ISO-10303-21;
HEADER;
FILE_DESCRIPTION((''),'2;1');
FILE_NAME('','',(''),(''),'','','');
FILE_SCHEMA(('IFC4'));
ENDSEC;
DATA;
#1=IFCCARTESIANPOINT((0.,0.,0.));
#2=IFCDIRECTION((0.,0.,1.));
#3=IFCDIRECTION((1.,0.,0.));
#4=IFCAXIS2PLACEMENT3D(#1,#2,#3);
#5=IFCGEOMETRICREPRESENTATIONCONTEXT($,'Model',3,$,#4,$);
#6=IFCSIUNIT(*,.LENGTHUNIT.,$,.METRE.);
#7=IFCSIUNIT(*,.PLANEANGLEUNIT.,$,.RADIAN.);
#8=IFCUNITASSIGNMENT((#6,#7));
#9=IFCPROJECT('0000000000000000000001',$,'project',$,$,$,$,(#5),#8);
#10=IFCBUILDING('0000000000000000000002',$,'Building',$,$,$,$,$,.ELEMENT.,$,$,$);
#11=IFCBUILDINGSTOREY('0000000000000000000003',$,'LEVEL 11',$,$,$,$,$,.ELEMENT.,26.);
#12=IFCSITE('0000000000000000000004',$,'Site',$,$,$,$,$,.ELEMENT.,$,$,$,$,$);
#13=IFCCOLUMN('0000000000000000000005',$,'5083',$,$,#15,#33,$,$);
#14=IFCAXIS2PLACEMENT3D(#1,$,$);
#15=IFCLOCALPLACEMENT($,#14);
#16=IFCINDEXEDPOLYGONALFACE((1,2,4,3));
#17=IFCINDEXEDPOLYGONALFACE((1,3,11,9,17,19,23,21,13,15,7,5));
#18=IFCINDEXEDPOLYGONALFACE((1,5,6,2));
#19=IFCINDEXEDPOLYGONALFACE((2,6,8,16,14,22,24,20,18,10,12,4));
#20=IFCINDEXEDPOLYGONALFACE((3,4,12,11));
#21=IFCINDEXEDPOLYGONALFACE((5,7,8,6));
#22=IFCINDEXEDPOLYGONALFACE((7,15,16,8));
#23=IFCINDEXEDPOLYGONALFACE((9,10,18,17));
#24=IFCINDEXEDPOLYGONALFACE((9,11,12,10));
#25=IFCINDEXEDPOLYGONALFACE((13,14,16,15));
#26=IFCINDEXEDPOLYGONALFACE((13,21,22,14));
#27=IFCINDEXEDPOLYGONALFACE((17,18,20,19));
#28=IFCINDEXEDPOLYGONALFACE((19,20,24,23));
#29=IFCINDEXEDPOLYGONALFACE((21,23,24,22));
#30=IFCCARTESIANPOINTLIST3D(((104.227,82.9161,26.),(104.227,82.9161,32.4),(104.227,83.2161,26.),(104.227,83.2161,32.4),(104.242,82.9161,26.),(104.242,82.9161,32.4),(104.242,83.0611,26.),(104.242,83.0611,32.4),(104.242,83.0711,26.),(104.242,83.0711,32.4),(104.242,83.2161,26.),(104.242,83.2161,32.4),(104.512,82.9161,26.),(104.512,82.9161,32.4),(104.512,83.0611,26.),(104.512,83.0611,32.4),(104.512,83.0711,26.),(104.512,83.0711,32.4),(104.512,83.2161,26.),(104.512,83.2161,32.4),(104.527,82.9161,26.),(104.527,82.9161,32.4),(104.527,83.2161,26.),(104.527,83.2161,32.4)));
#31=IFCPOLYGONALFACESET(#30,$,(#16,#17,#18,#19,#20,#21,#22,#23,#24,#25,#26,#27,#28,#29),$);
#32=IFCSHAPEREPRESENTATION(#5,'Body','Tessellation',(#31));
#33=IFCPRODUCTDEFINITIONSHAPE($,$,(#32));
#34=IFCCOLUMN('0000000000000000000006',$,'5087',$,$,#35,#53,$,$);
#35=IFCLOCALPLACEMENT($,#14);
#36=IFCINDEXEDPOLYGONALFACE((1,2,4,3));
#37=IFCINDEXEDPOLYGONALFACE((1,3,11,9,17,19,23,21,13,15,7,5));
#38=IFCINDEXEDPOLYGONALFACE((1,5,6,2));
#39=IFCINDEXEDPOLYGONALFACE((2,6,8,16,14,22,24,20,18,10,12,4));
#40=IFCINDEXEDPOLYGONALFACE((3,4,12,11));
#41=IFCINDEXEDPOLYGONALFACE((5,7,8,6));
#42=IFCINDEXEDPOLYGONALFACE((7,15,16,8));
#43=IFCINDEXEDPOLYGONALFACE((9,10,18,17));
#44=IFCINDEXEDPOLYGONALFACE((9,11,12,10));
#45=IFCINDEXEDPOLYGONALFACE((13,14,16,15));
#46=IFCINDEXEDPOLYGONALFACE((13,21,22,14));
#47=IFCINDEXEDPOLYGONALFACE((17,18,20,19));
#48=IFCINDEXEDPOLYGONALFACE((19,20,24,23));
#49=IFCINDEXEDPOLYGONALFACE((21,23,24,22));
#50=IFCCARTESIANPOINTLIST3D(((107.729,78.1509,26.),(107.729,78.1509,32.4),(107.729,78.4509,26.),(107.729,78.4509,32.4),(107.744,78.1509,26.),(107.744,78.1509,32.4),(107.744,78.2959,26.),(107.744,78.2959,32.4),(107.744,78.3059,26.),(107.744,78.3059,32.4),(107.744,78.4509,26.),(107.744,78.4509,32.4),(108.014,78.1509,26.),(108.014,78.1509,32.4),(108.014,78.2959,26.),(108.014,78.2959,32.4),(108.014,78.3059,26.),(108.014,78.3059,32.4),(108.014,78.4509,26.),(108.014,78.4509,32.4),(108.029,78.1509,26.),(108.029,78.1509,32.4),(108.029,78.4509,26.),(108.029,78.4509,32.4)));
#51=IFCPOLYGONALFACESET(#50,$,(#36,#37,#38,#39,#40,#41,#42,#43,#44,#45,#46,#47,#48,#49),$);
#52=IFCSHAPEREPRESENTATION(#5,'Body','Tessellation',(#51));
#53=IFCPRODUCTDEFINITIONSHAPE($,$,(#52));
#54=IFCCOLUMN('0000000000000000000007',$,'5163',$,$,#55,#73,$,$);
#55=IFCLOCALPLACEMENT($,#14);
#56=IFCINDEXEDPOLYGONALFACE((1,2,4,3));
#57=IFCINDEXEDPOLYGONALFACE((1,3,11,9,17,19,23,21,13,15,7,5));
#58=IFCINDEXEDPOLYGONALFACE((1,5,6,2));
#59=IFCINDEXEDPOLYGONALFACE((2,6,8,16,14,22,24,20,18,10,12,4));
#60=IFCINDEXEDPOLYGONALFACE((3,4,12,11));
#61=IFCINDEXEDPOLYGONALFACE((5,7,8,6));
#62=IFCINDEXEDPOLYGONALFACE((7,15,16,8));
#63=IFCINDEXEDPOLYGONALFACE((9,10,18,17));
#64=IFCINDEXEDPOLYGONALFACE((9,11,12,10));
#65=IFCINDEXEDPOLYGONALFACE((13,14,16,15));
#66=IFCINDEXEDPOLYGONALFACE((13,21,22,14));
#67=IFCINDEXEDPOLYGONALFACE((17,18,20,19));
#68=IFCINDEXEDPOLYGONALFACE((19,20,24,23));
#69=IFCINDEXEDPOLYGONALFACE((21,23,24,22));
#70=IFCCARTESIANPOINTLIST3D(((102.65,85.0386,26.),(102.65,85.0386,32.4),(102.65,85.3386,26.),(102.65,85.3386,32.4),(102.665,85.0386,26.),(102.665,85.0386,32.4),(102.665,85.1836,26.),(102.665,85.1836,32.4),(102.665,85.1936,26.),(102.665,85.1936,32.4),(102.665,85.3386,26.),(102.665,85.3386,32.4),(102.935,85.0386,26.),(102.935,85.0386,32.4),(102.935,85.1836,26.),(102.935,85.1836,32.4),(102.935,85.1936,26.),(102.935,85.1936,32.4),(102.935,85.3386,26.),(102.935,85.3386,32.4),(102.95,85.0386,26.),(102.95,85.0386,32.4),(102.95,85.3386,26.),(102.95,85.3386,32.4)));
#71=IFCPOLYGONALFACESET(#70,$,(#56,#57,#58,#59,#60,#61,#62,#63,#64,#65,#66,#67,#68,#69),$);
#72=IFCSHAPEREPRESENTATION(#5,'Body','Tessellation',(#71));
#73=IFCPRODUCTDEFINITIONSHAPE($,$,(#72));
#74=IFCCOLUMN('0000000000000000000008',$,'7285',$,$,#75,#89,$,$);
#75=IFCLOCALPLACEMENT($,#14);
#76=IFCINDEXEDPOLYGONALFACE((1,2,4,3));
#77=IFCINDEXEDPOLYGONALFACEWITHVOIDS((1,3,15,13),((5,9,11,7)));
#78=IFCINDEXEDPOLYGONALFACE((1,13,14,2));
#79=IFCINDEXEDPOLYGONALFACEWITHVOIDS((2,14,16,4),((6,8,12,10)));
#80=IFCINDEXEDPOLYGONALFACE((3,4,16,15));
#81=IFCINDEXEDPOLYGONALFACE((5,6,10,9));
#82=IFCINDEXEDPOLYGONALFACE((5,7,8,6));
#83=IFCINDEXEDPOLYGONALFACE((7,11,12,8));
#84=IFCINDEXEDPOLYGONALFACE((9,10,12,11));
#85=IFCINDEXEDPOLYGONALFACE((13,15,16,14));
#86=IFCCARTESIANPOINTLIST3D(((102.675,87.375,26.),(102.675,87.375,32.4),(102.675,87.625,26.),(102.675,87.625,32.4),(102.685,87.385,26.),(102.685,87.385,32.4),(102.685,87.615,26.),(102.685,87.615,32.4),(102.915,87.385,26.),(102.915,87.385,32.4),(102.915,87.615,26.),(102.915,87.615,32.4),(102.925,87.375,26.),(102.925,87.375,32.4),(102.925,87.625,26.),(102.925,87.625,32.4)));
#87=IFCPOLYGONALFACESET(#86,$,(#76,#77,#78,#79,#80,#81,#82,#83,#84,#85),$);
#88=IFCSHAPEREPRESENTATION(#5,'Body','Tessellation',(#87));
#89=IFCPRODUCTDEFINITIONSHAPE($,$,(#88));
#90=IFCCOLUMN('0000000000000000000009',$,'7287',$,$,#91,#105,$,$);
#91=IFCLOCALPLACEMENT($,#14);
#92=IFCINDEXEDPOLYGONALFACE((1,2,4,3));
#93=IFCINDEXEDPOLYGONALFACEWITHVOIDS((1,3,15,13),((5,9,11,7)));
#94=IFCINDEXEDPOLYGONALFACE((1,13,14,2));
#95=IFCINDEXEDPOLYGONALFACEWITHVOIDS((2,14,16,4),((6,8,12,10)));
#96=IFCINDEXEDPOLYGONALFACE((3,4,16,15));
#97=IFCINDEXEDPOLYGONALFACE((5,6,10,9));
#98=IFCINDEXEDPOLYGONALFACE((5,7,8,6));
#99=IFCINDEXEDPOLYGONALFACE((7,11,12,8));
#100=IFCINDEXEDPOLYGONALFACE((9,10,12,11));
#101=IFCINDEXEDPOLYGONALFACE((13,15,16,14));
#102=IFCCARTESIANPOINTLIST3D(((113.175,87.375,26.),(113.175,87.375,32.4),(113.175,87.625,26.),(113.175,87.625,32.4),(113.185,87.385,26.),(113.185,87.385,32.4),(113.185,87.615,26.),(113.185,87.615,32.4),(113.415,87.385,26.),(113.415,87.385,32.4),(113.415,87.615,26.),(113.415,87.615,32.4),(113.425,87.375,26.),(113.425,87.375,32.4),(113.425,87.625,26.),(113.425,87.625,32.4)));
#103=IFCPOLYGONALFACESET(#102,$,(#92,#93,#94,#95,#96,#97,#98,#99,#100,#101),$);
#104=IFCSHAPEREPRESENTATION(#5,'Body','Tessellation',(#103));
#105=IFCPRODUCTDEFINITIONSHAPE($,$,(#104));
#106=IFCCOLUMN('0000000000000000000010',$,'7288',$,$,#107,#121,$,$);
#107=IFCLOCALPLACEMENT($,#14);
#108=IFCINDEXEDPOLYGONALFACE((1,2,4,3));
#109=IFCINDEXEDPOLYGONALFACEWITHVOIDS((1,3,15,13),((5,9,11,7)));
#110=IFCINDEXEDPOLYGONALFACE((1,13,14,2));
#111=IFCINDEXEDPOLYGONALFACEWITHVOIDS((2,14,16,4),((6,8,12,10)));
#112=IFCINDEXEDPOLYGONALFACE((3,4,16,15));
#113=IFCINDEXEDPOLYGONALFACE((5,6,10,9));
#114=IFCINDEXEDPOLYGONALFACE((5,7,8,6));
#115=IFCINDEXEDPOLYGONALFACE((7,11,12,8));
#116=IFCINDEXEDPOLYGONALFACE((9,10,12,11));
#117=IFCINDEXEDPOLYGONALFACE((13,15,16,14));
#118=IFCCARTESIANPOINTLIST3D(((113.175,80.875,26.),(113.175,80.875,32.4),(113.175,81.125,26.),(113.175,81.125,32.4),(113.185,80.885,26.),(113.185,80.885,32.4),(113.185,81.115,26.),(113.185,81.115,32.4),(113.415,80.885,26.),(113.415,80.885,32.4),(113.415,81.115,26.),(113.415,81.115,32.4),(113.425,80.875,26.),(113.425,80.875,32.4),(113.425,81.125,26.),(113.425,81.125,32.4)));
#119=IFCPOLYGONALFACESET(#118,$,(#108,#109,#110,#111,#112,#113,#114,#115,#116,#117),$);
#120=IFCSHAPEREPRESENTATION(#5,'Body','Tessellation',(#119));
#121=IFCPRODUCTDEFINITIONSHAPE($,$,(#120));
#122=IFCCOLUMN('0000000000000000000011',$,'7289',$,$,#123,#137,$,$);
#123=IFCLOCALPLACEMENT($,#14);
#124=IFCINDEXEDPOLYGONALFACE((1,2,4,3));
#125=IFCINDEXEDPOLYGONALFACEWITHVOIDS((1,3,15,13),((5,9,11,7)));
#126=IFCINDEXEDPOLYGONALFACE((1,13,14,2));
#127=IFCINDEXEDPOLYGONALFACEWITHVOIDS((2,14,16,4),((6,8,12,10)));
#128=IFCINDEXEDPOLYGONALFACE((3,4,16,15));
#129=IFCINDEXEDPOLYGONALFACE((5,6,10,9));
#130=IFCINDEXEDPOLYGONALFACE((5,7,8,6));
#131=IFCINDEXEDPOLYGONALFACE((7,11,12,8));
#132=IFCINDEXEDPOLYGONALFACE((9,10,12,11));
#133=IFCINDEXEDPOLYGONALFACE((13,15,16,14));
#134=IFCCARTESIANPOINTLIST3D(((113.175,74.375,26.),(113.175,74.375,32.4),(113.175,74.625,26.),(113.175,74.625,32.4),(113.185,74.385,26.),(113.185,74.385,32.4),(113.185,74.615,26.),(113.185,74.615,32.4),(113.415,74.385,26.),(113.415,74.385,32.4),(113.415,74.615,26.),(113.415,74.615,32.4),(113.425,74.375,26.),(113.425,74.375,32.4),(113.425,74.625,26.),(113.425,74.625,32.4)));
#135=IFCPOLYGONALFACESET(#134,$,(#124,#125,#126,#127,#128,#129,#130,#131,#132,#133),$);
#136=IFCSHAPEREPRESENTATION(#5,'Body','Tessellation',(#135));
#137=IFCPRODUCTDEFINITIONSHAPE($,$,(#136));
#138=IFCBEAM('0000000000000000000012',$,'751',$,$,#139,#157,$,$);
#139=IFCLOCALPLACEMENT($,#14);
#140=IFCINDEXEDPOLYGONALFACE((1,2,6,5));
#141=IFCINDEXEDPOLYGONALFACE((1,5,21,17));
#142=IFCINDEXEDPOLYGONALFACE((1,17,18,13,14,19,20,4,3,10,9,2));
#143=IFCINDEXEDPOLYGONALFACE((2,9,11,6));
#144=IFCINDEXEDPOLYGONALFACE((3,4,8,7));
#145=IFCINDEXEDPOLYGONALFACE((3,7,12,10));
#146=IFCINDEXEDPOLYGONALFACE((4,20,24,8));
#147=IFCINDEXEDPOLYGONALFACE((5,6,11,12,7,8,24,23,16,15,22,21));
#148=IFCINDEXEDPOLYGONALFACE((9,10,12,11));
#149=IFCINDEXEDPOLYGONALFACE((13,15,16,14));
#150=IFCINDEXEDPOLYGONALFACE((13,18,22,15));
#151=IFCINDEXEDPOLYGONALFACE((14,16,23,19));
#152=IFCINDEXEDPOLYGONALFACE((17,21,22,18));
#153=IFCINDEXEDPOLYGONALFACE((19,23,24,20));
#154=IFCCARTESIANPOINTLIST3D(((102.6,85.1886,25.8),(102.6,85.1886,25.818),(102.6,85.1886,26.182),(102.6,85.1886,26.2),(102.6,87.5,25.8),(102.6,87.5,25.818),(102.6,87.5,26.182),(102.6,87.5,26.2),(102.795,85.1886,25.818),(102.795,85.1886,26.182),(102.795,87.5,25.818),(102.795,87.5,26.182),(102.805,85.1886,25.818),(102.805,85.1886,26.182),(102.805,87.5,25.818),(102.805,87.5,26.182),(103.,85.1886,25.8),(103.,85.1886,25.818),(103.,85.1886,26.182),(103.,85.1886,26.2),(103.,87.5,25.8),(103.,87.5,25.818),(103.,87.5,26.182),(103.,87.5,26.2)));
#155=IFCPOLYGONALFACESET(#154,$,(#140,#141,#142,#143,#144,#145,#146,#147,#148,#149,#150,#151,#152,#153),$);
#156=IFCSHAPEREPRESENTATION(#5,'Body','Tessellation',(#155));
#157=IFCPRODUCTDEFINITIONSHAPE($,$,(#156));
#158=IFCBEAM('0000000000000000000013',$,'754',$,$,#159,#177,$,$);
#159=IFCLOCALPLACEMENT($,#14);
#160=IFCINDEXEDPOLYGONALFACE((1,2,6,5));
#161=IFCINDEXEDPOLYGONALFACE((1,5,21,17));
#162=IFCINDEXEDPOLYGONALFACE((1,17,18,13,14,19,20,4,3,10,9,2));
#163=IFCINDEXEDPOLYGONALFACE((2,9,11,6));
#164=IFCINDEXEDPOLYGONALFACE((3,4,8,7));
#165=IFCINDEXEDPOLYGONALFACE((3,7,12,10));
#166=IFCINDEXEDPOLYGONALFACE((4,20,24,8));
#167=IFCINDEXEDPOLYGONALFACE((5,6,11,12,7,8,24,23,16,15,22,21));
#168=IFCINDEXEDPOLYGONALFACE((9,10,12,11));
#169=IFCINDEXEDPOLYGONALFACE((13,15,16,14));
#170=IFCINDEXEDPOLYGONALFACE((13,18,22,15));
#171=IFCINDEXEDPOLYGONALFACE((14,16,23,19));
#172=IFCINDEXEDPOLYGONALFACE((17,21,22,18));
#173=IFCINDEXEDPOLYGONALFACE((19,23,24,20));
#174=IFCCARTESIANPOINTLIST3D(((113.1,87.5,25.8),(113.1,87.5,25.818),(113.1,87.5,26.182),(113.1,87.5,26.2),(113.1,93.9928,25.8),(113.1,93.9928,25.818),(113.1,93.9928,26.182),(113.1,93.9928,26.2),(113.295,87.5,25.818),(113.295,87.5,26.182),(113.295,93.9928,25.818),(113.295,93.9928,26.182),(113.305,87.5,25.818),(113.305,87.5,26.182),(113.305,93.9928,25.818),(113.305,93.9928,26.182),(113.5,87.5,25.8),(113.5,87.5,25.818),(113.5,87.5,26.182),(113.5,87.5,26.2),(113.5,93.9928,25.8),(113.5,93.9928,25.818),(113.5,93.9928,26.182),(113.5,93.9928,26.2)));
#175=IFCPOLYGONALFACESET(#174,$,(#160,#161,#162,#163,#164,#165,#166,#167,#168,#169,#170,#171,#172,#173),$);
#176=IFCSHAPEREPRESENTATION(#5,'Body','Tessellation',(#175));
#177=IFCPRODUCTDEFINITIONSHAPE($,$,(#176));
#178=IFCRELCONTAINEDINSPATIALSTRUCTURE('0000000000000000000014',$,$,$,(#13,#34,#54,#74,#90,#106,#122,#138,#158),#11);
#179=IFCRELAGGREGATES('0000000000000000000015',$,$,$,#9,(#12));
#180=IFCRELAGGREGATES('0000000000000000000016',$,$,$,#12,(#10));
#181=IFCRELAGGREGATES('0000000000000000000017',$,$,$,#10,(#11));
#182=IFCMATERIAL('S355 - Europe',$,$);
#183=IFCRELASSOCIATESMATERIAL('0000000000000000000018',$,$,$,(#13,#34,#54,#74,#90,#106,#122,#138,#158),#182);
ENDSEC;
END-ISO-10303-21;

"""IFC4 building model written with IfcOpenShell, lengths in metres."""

from ifc_helpers import new_model, si_unit, frame, origin_with_axes, origin_2d_with_axis, place, context, project, spatial, hollow_rectangle, i_section, extrude, material, material_profile, profile_set, profile_usage, element, save


model = new_model("IFC4")

# Units and contexts
model_context = context("Model", 3, world=origin_with_axes())
ifc_project = project(units=[si_unit("LENGTHUNIT", "METRE"), si_unit("PLANEANGLEUNIT", "RADIAN")], contexts=[model_context])

# Site, building, storey
site = spatial("IfcSite", under=ifc_project, Name="Site", CompositionType="ELEMENT")
building = spatial("IfcBuilding", under=site, Name="Building", CompositionType="ELEMENT")
storey = spatial("IfcBuildingStorey", under=building, Name="LEVEL 11", CompositionType="ELEMENT", Elevation=26.0)

# Columns
ifc_material = material(Name="S355 - Europe")
ifc_material_profile_1 = material_profile(ifc_material, i_section(OverallWidth=0.3, OverallDepth=0.3, WebThickness=0.01, FlangeThickness=0.015, at=origin_2d_with_axis()))
ifc_profile_set_1 = profile_set([ifc_material_profile_1])
ifc_profile_usage_1 = profile_usage(ifc_profile_set_1, cardinal=10)
column_1_placement = place(None, frame((104.377, 83.0661, 26.0), z_axis=(0.0, 0.0, 1.0), x_axis=(0.0, -1.0, 0.0)))
element("IfcColumn", 1, at=column_1_placement, inside=storey, material=ifc_profile_usage_1, Name="5083", context=model_context, shape_type="SweptSolid", body=[
    extrude(i_section(OverallWidth=0.3, OverallDepth=0.3, WebThickness=0.01, FlangeThickness=0.015, at=origin_2d_with_axis()), origin_with_axes(), (0.0, 0.0, 1.0), 6.4),
])
ifc_material_profile_2 = material_profile(ifc_material, i_section(OverallWidth=0.3, OverallDepth=0.3, WebThickness=0.01, FlangeThickness=0.015, at=origin_2d_with_axis()))
ifc_profile_set_2 = profile_set([ifc_material_profile_2])
ifc_profile_usage_2 = profile_usage(ifc_profile_set_2, cardinal=10)
column_2_placement = place(None, frame((107.879, 78.3009, 26.0), z_axis=(0.0, 0.0, 1.0), x_axis=(0.0, -1.0, 0.0)))
element("IfcColumn", 2, at=column_2_placement, inside=storey, material=ifc_profile_usage_2, Name="5087", context=model_context, shape_type="SweptSolid", body=[
    extrude(i_section(OverallWidth=0.3, OverallDepth=0.3, WebThickness=0.01, FlangeThickness=0.015, at=origin_2d_with_axis()), origin_with_axes(), (0.0, 0.0, 1.0), 6.4),
])
ifc_material_profile_3 = material_profile(ifc_material, i_section(OverallWidth=0.3, OverallDepth=0.3, WebThickness=0.01, FlangeThickness=0.015, at=origin_2d_with_axis()))
ifc_profile_set_3 = profile_set([ifc_material_profile_3])
ifc_profile_usage_3 = profile_usage(ifc_profile_set_3, cardinal=10)
column_3_placement = place(None, frame((102.8, 85.1886, 26.0), z_axis=(0.0, 0.0, 1.0), x_axis=(0.0, -1.0, 0.0)))
element("IfcColumn", 3, at=column_3_placement, inside=storey, material=ifc_profile_usage_3, Name="5163", context=model_context, shape_type="SweptSolid", body=[
    extrude(i_section(OverallWidth=0.3, OverallDepth=0.3, WebThickness=0.01, FlangeThickness=0.015, at=origin_2d_with_axis()), origin_with_axes(), (0.0, 0.0, 1.0), 6.4),
])
ifc_material_profile_4 = material_profile(ifc_material, hollow_rectangle(XDim=0.25, YDim=0.25, WallThickness=0.01, at=origin_2d_with_axis()))
ifc_profile_set_4 = profile_set([ifc_material_profile_4])
ifc_profile_usage_4 = profile_usage(ifc_profile_set_4, cardinal=10)
column_4_placement = place(None, frame((102.8, 87.5, 26.0), z_axis=(0.0, 0.0, 1.0), x_axis=(0.0, -1.0, 0.0)))
element("IfcColumn", 4, at=column_4_placement, inside=storey, material=ifc_profile_usage_4, Name="7285", context=model_context, shape_type="SweptSolid", body=[
    extrude(hollow_rectangle(XDim=0.25, YDim=0.25, WallThickness=0.01, at=origin_2d_with_axis()), origin_with_axes(), (0.0, 0.0, 1.0), 6.4),
])
ifc_material_profile_5 = material_profile(ifc_material, hollow_rectangle(XDim=0.25, YDim=0.25, WallThickness=0.01, at=origin_2d_with_axis()))
ifc_profile_set_5 = profile_set([ifc_material_profile_5])
ifc_profile_usage_5 = profile_usage(ifc_profile_set_5, cardinal=10)
column_5_placement = place(None, frame((113.3, 87.5, 26.0), z_axis=(0.0, 0.0, 1.0), x_axis=(0.0, -1.0, 0.0)))
element("IfcColumn", 5, at=column_5_placement, inside=storey, material=ifc_profile_usage_5, Name="7287", context=model_context, shape_type="SweptSolid", body=[
    extrude(hollow_rectangle(XDim=0.25, YDim=0.25, WallThickness=0.01, at=origin_2d_with_axis()), origin_with_axes(), (0.0, 0.0, 1.0), 6.4),
])
ifc_material_profile_6 = material_profile(ifc_material, hollow_rectangle(XDim=0.25, YDim=0.25, WallThickness=0.01, at=origin_2d_with_axis()))
ifc_profile_set_6 = profile_set([ifc_material_profile_6])
ifc_profile_usage_6 = profile_usage(ifc_profile_set_6, cardinal=10)
column_6_placement = place(None, frame((113.3, 81.0, 26.0), z_axis=(0.0, 0.0, 1.0), x_axis=(0.0, -1.0, 0.0)))
element("IfcColumn", 6, at=column_6_placement, inside=storey, material=ifc_profile_usage_6, Name="7288", context=model_context, shape_type="SweptSolid", body=[
    extrude(hollow_rectangle(XDim=0.25, YDim=0.25, WallThickness=0.01, at=origin_2d_with_axis()), origin_with_axes(), (0.0, 0.0, 1.0), 6.4),
])
ifc_material_profile_7 = material_profile(ifc_material, hollow_rectangle(XDim=0.25, YDim=0.25, WallThickness=0.01, at=origin_2d_with_axis()))
ifc_profile_set_7 = profile_set([ifc_material_profile_7])
ifc_profile_usage_7 = profile_usage(ifc_profile_set_7, cardinal=10)
column_7_placement = place(None, frame((113.3, 74.5, 26.0), z_axis=(0.0, 0.0, 1.0), x_axis=(0.0, -1.0, 0.0)))
element("IfcColumn", 7, at=column_7_placement, inside=storey, material=ifc_profile_usage_7, Name="7289", context=model_context, shape_type="SweptSolid", body=[
    extrude(hollow_rectangle(XDim=0.25, YDim=0.25, WallThickness=0.01, at=origin_2d_with_axis()), origin_with_axes(), (0.0, 0.0, 1.0), 6.4),
])

# Beams
ifc_material_profile_8 = material_profile(ifc_material, i_section(OverallWidth=0.4, OverallDepth=0.4, WebThickness=0.01, FlangeThickness=0.018, at=origin_2d_with_axis()))
ifc_profile_set_8 = profile_set([ifc_material_profile_8])
ifc_profile_usage_8 = profile_usage(ifc_profile_set_8, cardinal=10)
beam_1_placement = place(None, frame((102.8, 87.5, 26.0), z_axis=(0.0, -1.0, 0.0), x_axis=(1.0, 0.0, 0.0)))
element("IfcBeam", 8, at=beam_1_placement, inside=storey, material=ifc_profile_usage_8, Name="751", context=model_context, shape_type="SweptSolid", body=[
    extrude(i_section(OverallWidth=0.4, OverallDepth=0.4, WebThickness=0.01, FlangeThickness=0.018, at=origin_2d_with_axis()), origin_with_axes(), (0.0, 0.0, 1.0), 2.3114),
])
ifc_material_profile_9 = material_profile(ifc_material, i_section(OverallWidth=0.4, OverallDepth=0.4, WebThickness=0.01, FlangeThickness=0.018, at=origin_2d_with_axis()))
ifc_profile_set_9 = profile_set([ifc_material_profile_9])
ifc_profile_usage_9 = profile_usage(ifc_profile_set_9, cardinal=10)
beam_2_placement = place(None, frame((113.3, 87.5, 26.0), z_axis=(0.0, 1.0, 0.0), x_axis=(-1.0, 0.0, 0.0)))
element("IfcBeam", 9, at=beam_2_placement, inside=storey, material=ifc_profile_usage_9, Name="754", context=model_context, shape_type="SweptSolid", body=[
    extrude(i_section(OverallWidth=0.4, OverallDepth=0.4, WebThickness=0.01, FlangeThickness=0.018, at=origin_2d_with_axis()), origin_with_axes(), (0.0, 0.0, 1.0), 6.4928),
])

save(model, "model.ifc")
